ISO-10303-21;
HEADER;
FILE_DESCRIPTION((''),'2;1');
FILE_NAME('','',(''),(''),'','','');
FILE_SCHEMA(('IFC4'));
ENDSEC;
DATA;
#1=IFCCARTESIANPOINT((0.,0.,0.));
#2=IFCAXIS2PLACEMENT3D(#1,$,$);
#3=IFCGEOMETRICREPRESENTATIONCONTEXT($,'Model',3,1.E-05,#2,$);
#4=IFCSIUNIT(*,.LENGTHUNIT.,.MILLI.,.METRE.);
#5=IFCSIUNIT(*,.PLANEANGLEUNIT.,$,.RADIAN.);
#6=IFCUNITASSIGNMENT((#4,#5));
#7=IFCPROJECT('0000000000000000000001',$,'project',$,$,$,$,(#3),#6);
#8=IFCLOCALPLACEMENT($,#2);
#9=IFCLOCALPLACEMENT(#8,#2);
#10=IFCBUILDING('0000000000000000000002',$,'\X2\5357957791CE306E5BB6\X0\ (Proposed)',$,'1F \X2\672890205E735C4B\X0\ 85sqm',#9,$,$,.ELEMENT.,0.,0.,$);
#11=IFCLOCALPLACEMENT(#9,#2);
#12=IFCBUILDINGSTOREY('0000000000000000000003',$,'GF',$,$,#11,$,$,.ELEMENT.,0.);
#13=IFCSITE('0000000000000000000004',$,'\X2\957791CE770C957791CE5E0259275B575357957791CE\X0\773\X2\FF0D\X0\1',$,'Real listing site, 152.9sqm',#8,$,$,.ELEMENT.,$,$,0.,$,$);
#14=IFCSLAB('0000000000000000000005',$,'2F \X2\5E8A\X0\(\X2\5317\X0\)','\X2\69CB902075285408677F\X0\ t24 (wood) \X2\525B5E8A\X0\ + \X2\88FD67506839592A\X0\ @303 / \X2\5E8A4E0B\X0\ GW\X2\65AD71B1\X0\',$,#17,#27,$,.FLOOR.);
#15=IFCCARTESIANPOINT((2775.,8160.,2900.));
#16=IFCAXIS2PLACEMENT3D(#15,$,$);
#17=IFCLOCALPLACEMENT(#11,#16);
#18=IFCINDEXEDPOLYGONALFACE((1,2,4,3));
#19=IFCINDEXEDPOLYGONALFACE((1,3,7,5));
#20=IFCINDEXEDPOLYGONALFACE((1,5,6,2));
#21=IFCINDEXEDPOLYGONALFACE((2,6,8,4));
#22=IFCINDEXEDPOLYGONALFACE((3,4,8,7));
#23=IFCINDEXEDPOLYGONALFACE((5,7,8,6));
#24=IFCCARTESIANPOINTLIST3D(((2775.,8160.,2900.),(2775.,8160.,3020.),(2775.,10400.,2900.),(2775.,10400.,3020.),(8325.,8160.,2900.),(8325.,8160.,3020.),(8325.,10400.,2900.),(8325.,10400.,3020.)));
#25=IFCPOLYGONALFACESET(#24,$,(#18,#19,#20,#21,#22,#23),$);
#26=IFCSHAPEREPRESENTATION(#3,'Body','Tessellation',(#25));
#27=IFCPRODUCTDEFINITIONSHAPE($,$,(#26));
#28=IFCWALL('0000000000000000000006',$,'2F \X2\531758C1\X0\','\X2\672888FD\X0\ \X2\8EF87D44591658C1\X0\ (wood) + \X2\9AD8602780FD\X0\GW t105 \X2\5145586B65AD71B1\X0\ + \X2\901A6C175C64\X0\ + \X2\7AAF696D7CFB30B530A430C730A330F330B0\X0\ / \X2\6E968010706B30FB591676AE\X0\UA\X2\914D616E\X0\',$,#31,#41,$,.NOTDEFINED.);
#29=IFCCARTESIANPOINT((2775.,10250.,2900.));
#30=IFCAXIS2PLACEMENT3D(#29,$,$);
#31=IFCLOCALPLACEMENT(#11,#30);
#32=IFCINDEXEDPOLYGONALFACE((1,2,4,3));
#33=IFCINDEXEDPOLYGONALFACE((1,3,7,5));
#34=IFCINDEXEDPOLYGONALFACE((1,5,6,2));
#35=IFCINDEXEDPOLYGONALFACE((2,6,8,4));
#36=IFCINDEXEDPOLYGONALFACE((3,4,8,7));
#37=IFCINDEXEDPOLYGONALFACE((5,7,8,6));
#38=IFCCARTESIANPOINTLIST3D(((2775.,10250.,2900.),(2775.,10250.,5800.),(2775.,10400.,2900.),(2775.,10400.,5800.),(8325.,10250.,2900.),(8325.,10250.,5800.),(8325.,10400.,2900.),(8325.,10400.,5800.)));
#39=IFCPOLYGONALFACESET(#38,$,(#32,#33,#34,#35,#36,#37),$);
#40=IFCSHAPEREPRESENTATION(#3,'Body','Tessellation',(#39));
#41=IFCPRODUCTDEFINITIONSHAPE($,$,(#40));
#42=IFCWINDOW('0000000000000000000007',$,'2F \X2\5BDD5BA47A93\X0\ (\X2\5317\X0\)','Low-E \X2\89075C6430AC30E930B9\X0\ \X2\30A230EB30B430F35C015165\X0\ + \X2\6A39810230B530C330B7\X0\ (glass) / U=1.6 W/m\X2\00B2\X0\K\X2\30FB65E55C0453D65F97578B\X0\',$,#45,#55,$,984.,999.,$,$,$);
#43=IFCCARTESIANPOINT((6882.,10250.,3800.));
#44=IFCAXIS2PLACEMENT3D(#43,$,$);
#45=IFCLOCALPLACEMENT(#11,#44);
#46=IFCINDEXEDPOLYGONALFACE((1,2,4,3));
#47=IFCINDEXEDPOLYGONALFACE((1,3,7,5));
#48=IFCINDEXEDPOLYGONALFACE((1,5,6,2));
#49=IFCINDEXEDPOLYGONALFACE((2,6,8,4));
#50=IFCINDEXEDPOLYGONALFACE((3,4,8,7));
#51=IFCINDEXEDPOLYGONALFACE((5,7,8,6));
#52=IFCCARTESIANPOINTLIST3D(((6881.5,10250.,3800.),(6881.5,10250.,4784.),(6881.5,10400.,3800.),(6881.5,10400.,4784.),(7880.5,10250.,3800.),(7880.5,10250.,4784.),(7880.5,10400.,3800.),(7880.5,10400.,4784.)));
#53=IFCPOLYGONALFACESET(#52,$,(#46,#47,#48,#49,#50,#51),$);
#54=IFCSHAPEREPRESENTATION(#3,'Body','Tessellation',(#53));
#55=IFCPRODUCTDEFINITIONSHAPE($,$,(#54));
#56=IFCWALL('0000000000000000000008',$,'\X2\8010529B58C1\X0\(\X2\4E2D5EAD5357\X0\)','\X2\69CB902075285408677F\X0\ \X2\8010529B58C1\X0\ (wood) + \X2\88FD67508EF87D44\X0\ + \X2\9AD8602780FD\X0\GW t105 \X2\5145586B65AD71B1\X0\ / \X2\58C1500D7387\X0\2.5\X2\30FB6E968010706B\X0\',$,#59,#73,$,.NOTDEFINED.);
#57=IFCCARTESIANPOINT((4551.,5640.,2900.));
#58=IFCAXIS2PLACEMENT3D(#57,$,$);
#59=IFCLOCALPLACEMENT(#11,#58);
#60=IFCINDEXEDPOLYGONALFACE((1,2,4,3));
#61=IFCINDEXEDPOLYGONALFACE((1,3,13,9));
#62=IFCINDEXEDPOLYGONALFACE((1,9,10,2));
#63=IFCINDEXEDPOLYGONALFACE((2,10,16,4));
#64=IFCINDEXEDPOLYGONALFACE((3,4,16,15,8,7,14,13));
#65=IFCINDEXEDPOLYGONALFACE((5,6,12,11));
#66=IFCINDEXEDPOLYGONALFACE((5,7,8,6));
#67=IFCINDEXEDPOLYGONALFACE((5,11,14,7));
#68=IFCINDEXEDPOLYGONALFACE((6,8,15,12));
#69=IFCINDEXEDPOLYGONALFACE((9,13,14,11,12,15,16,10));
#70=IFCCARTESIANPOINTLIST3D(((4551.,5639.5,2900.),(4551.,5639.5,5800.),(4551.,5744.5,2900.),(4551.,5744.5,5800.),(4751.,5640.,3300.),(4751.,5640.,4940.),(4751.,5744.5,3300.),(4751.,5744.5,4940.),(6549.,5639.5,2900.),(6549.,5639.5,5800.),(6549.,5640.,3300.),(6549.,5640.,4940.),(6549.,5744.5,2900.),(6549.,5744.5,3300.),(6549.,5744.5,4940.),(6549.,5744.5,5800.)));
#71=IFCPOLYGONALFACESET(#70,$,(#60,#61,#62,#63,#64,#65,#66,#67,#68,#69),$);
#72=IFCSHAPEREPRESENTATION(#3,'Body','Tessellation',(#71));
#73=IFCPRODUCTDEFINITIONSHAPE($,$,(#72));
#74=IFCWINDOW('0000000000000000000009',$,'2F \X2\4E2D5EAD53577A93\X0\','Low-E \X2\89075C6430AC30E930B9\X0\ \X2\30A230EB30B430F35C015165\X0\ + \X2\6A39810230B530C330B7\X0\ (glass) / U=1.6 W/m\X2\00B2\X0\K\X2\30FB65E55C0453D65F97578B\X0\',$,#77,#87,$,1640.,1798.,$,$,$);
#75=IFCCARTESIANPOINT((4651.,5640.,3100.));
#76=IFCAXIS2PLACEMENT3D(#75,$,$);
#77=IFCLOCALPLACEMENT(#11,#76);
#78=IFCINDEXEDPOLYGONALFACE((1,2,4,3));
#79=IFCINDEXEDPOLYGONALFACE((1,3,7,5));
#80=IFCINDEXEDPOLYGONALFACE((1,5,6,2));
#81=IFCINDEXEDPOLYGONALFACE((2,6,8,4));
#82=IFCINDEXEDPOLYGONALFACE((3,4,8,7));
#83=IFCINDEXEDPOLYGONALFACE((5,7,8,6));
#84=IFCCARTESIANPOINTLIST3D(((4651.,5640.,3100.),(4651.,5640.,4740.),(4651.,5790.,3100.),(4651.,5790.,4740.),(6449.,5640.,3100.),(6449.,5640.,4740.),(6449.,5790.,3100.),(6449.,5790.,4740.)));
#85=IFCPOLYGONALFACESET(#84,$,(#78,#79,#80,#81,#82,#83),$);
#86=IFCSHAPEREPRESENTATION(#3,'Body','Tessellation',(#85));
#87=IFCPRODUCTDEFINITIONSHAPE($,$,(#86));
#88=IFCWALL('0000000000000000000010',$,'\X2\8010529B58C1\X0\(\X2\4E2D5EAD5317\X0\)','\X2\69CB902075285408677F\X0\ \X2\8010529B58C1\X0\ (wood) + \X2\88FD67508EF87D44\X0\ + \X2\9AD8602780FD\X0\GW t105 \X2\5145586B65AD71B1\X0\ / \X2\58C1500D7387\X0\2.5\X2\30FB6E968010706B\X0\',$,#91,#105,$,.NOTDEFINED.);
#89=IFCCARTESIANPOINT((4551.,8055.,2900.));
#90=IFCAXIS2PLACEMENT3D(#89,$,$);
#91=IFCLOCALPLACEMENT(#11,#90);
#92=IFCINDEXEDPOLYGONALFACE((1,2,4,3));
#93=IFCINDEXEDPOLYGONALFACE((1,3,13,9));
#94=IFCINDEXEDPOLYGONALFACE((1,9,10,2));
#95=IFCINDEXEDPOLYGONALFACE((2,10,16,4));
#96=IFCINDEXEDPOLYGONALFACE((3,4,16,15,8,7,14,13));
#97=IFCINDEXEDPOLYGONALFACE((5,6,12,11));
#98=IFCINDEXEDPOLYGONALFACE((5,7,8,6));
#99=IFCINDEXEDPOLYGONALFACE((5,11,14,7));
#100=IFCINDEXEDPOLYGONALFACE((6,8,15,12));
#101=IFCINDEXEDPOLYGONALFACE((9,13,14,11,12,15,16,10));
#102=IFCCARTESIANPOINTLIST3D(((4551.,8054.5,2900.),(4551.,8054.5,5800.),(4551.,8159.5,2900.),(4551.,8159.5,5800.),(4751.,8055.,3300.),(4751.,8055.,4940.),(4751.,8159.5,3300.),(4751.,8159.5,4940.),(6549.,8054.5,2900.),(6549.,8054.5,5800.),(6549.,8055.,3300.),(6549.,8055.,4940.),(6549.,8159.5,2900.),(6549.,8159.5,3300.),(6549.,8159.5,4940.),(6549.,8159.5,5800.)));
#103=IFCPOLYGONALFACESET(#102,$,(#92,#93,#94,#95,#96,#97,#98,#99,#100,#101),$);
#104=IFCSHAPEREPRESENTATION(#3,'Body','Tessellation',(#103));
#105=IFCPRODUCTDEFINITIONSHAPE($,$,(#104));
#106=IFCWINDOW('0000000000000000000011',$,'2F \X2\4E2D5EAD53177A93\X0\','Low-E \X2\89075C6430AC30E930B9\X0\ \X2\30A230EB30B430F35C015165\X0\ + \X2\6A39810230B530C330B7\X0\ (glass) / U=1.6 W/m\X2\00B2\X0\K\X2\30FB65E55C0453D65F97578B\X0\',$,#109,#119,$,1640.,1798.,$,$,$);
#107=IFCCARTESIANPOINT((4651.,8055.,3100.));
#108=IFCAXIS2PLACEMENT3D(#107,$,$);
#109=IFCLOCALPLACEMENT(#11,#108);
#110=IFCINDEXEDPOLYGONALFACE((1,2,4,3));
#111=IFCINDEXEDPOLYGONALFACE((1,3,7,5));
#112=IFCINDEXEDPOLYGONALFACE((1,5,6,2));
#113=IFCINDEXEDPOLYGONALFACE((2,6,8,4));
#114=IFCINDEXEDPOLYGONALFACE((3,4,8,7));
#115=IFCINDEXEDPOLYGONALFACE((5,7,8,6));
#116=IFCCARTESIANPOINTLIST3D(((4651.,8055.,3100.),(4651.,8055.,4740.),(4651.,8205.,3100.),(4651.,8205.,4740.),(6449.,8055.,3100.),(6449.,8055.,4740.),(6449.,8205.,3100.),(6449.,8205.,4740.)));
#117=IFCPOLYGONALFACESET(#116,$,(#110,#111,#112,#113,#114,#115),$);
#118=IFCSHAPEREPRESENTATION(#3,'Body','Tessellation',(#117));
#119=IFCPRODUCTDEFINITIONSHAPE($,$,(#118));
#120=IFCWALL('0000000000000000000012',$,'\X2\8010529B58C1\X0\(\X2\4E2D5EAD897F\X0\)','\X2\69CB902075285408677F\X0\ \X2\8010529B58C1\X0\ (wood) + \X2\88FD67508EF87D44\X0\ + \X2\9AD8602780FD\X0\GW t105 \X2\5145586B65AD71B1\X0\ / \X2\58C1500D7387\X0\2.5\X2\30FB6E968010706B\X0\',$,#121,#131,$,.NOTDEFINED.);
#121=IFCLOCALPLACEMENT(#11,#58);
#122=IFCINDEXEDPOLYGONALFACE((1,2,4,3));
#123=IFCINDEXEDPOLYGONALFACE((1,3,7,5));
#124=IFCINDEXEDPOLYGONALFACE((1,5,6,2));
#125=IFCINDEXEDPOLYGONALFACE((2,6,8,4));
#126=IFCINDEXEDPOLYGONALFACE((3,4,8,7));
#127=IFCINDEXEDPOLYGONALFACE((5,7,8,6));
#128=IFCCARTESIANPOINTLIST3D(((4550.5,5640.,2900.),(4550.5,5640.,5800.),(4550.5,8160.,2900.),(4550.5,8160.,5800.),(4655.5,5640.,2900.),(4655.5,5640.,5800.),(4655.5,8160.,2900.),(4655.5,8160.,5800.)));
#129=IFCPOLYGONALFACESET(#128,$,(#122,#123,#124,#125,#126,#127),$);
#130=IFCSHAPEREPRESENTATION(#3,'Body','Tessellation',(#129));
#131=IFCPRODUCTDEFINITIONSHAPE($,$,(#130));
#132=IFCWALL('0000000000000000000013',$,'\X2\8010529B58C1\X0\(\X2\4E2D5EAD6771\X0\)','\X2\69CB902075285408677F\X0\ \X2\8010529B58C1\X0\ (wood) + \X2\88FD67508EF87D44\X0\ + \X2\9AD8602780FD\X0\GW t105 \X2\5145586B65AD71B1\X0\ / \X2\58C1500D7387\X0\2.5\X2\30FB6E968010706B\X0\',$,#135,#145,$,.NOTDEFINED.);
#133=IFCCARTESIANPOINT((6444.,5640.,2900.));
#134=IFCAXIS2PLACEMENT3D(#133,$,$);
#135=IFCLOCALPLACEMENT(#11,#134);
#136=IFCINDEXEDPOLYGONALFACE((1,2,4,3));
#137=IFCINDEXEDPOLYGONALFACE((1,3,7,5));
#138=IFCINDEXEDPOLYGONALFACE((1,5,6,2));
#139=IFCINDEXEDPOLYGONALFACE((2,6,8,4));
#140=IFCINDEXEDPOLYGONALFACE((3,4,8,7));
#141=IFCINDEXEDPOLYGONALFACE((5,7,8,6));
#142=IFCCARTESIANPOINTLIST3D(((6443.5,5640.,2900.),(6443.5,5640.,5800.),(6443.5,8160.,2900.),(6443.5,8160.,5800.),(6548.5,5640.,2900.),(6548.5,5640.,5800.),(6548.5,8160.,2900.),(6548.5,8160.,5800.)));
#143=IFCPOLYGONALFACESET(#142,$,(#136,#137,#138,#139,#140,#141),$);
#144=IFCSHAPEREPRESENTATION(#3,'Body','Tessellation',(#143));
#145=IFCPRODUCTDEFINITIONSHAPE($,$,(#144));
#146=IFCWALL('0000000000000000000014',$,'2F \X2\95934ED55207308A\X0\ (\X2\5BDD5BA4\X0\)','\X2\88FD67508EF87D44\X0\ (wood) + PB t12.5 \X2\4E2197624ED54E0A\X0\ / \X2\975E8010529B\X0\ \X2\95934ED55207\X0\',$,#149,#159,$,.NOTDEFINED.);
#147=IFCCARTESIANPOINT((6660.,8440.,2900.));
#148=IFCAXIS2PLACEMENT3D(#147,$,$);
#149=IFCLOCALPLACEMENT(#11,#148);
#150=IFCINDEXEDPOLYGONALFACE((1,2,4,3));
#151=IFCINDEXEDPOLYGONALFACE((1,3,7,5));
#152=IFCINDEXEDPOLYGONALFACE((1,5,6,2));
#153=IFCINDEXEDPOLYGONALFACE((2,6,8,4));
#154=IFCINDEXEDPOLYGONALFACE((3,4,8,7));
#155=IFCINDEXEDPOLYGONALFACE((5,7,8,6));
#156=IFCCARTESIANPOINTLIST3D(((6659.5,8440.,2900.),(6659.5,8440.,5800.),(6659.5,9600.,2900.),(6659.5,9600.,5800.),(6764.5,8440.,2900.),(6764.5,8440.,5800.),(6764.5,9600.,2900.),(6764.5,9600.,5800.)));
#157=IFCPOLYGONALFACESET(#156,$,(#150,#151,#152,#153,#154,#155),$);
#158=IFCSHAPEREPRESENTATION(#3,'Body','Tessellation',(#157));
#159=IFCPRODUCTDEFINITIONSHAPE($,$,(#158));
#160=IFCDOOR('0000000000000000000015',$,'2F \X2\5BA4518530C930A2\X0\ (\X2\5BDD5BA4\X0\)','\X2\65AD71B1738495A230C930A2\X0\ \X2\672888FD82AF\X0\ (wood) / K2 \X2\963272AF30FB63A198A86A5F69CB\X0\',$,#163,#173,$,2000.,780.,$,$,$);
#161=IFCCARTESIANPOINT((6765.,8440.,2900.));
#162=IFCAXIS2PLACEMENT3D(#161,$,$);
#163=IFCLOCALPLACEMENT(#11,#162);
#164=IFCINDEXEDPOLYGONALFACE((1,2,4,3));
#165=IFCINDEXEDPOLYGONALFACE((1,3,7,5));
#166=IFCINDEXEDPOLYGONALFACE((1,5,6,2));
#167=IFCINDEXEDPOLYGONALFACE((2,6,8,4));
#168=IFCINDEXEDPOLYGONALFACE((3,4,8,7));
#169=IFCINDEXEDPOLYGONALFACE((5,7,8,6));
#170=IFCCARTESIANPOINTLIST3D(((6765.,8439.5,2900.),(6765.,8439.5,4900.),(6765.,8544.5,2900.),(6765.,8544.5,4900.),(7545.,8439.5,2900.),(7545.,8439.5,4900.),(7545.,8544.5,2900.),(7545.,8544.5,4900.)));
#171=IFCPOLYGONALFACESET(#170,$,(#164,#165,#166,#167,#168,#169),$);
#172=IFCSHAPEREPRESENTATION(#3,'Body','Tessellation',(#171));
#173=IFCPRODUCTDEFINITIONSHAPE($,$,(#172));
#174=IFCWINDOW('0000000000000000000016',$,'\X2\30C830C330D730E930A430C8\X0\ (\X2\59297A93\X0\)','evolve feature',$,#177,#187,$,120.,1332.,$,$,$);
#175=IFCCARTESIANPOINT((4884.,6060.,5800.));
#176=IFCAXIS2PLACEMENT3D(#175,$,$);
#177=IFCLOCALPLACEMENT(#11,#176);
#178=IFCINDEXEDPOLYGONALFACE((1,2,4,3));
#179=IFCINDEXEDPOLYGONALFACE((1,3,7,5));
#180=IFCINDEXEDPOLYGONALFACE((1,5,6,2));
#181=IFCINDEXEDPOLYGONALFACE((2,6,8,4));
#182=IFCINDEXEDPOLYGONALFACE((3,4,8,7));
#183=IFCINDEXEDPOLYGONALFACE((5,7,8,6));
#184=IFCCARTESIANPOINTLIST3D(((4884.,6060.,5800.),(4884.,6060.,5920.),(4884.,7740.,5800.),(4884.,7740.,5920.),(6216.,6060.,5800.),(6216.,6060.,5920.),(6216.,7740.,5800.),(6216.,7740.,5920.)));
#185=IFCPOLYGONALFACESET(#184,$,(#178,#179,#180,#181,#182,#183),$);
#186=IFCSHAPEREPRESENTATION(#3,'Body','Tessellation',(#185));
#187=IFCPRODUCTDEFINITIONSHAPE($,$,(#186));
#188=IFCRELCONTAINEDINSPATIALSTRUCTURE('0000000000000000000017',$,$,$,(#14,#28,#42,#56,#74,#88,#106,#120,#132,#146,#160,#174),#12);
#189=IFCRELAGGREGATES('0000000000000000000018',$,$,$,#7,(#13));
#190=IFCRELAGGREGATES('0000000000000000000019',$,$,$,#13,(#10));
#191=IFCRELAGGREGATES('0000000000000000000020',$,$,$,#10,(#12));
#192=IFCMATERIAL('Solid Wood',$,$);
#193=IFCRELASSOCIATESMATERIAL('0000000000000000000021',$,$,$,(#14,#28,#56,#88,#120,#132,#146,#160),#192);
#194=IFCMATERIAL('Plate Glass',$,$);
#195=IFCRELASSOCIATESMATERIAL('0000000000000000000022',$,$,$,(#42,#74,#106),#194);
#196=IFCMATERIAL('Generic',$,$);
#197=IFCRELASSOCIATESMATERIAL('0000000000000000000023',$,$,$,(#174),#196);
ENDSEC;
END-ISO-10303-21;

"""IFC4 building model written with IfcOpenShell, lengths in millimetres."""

from ifc_helpers import new_model, si_unit, frame, frame_2d, origin, place, context, project, spatial, rectangle, extrude, material, element, fill, save


model = new_model("IFC4")

# Units and contexts
model_context = context("Model", 3, precision=1e-05, world=origin())
ifc_project = project(units=[si_unit("LENGTHUNIT", "METRE", prefix="MILLI"), si_unit("PLANEANGLEUNIT", "RADIAN")], contexts=[model_context])

# Site, building, storey
site_placement = place(None, origin())
site = spatial("IfcSite", under=ifc_project, at=site_placement, Name="長野県長野市大字南長野773－1", ObjectType="Real listing site, 152.9sqm", CompositionType="ELEMENT", RefElevation=0.0)
building_placement = place(site_placement, origin())
building = spatial("IfcBuilding", under=site, at=building_placement, Name="南長野の家 (Proposed)", ObjectType="1F 木造平屋 85sqm", CompositionType="ELEMENT", ElevationOfRefHeight=0.0, ElevationOfTerrain=0.0)
storey_placement = place(building_placement, origin())
storey = spatial("IfcBuildingStorey", under=building, at=storey_placement, Name="GF", CompositionType="ELEMENT", Elevation=0.0)

# Slab
ifc_material_1 = material(Name="Solid Wood")
slab_placement = place(storey_placement, frame((2775.0, 8160.0, 2900.0)))
element("IfcSlab", 1, at=slab_placement, inside=storey, material=ifc_material_1, Name="2F 床(北)", Description="構造用合板 t24 (wood) 剛床 + 製材根太 @303 / 床下 GW断熱", PredefinedType="FLOOR", context=model_context, shape_type="SweptSolid", body=[
    extrude(rectangle(XDim=5550.0, YDim=2240.0, at=frame_2d((2775.0, 1120.0))), frame((2775.0, 8160.0, 2900.0)), (0.0, 0.0, 1.0), 120.0),
])

# Walls, openings, windows
wall_1_placement = place(storey_placement, frame((2775.0, 10250.0, 2900.0)))
wall_1 = element("IfcWall", 2, at=wall_1_placement, inside=storey, material=ifc_material_1, Name="2F 北壁", Description="木製 軸組外壁 (wood) + 高性能GW t105 充填断熱 + 通気層 + 窯業系サイディング / 準耐火・外皮UA配慮", PredefinedType="NOTDEFINED", context=model_context, shape_type="SweptSolid", body=[
    extrude(rectangle(XDim=5550.0, YDim=150.0, at=frame_2d((2775.0, 75.0))), frame((2775.0, 10250.0, 2900.0)), (0.0, 0.0, 1.0), 2900.0),
])
opening_1_placement = place(storey_placement, frame((6882.0, 10250.0, 3800.0)))
opening_1 = element("IfcOpeningElement", 3, at=opening_1_placement, cuts=wall_1, PredefinedType="NOTDEFINED", context=model_context, shape_type="SweptSolid", body=[
    extrude(rectangle(XDim=999.0, YDim=150.0, at=frame_2d((499.0, 75.0))), frame((6882.0, 10250.0, 3800.0)), (0.0, 0.0, 1.0), 984.0),
])
ifc_material_2 = material(Name="Plate Glass")
window_1_placement = place(storey_placement, frame((6882.0, 10250.0, 3800.0)))
window_1 = element("IfcWindow", 4, at=window_1_placement, inside=storey, material=ifc_material_2, Name="2F 寝室窓 (北)", Description="Low-E 複層ガラス アルゴン封入 + 樹脂サッシ (glass) / U=1.6 W/m²K・日射取得型", OverallHeight=984.0, OverallWidth=999.0, context=model_context, shape_type="SweptSolid", body=[
    extrude(rectangle(XDim=999.0, YDim=150.0, at=frame_2d((499.0, 75.0))), frame((6882.0, 10250.0, 3800.0)), (0.0, 0.0, 1.0), 984.0),
])
fill(opening_1, window_1)
wall_2_placement = place(storey_placement, frame((4551.0, 5640.0, 2900.0)))
wall_2 = element("IfcWall", 5, at=wall_2_placement, inside=storey, material=ifc_material_1, Name="耐力壁(中庭南)", Description="構造用合板 耐力壁 (wood) + 製材軸組 + 高性能GW t105 充填断熱 / 壁倍率2.5・準耐火", PredefinedType="NOTDEFINED", context=model_context, shape_type="SweptSolid", body=[
    extrude(rectangle(XDim=1998.0, YDim=105.0, at=frame_2d((999.0, 52.0))), frame((4551.0, 5640.0, 2900.0)), (0.0, 0.0, 1.0), 2900.0),
])
opening_2_placement = place(storey_placement, frame((4651.0, 5640.0, 3100.0)))
opening_2 = element("IfcOpeningElement", 6, at=opening_2_placement, cuts=wall_2, PredefinedType="NOTDEFINED", context=model_context, shape_type="SweptSolid", body=[
    extrude(rectangle(XDim=1798.0, YDim=150.0, at=frame_2d((899.0, 75.0))), frame((4651.0, 5640.0, 3100.0)), (0.0, 0.0, 1.0), 1640.0),
])
window_2_placement = place(storey_placement, frame((4651.0, 5640.0, 3100.0)))
window_2 = element("IfcWindow", 7, at=window_2_placement, inside=storey, material=ifc_material_2, Name="2F 中庭南窓", Description="Low-E 複層ガラス アルゴン封入 + 樹脂サッシ (glass) / U=1.6 W/m²K・日射取得型", OverallHeight=1640.0, OverallWidth=1798.0, context=model_context, shape_type="SweptSolid", body=[
    extrude(rectangle(XDim=1798.0, YDim=150.0, at=frame_2d((899.0, 75.0))), frame((4651.0, 5640.0, 3100.0)), (0.0, 0.0, 1.0), 1640.0),
])
fill(opening_2, window_2)
wall_3_placement = place(storey_placement, frame((4551.0, 8055.0, 2900.0)))
wall_3 = element("IfcWall", 8, at=wall_3_placement, inside=storey, material=ifc_material_1, Name="耐力壁(中庭北)", Description="構造用合板 耐力壁 (wood) + 製材軸組 + 高性能GW t105 充填断熱 / 壁倍率2.5・準耐火", PredefinedType="NOTDEFINED", context=model_context, shape_type="SweptSolid", body=[
    extrude(rectangle(XDim=1998.0, YDim=105.0, at=frame_2d((999.0, 52.0))), frame((4551.0, 8055.0, 2900.0)), (0.0, 0.0, 1.0), 2900.0),
])
opening_3_placement = place(storey_placement, frame((4651.0, 8055.0, 3100.0)))
opening_3 = element("IfcOpeningElement", 9, at=opening_3_placement, cuts=wall_3, PredefinedType="NOTDEFINED", context=model_context, shape_type="SweptSolid", body=[
    extrude(rectangle(XDim=1798.0, YDim=150.0, at=frame_2d((899.0, 75.0))), frame((4651.0, 8055.0, 3100.0)), (0.0, 0.0, 1.0), 1640.0),
])
window_3_placement = place(storey_placement, frame((4651.0, 8055.0, 3100.0)))
window_3 = element("IfcWindow", 10, at=window_3_placement, inside=storey, material=ifc_material_2, Name="2F 中庭北窓", Description="Low-E 複層ガラス アルゴン封入 + 樹脂サッシ (glass) / U=1.6 W/m²K・日射取得型", OverallHeight=1640.0, OverallWidth=1798.0, context=model_context, shape_type="SweptSolid", body=[
    extrude(rectangle(XDim=1798.0, YDim=150.0, at=frame_2d((899.0, 75.0))), frame((4651.0, 8055.0, 3100.0)), (0.0, 0.0, 1.0), 1640.0),
])
fill(opening_3, window_3)

# Walls
wall_4_placement = place(storey_placement, frame((4551.0, 5640.0, 2900.0)))
element("IfcWall", 11, at=wall_4_placement, inside=storey, material=ifc_material_1, Name="耐力壁(中庭西)", Description="構造用合板 耐力壁 (wood) + 製材軸組 + 高性能GW t105 充填断熱 / 壁倍率2.5・準耐火", PredefinedType="NOTDEFINED", context=model_context, shape_type="SweptSolid", body=[
    extrude(rectangle(XDim=105.0, YDim=2520.0, at=frame_2d((52.0, 1260.0))), frame((4551.0, 5640.0, 2900.0)), (0.0, 0.0, 1.0), 2900.0),
])
wall_5_placement = place(storey_placement, frame((6444.0, 5640.0, 2900.0)))
element("IfcWall", 12, at=wall_5_placement, inside=storey, material=ifc_material_1, Name="耐力壁(中庭東)", Description="構造用合板 耐力壁 (wood) + 製材軸組 + 高性能GW t105 充填断熱 / 壁倍率2.5・準耐火", PredefinedType="NOTDEFINED", context=model_context, shape_type="SweptSolid", body=[
    extrude(rectangle(XDim=105.0, YDim=2520.0, at=frame_2d((52.0, 1260.0))), frame((6444.0, 5640.0, 2900.0)), (0.0, 0.0, 1.0), 2900.0),
])
wall_6_placement = place(storey_placement, frame((6660.0, 8440.0, 2900.0)))
element("IfcWall", 13, at=wall_6_placement, inside=storey, material=ifc_material_1, Name="2F 間仕切り (寝室)", Description="製材軸組 (wood) + PB t12.5 両面仕上 / 非耐力 間仕切", PredefinedType="NOTDEFINED", context=model_context, shape_type="SweptSolid", body=[
    extrude(rectangle(XDim=105.0, YDim=1160.0, at=frame_2d((52.0, 580.0))), frame((6660.0, 8440.0, 2900.0)), (0.0, 0.0, 1.0), 2900.0),
])

# Door
door_placement = place(storey_placement, frame((6765.0, 8440.0, 2900.0)))
element("IfcDoor", 14, at=door_placement, inside=storey, material=ifc_material_1, Name="2F 室内ドア (寝室)", Description="断熱玄関ドア 木製芯 (wood) / K2 防犯・採風機構", OverallHeight=2000.0, OverallWidth=780.0, context=model_context, shape_type="SweptSolid", body=[
    extrude(rectangle(XDim=780.0, YDim=105.0, at=frame_2d((390.0, 52.0))), frame((6765.0, 8440.0, 2900.0)), (0.0, 0.0, 1.0), 2000.0),
])

# Window
ifc_material_3 = material(Name="Generic")
window_4_placement = place(storey_placement, frame((4884.0, 6060.0, 5800.0)))
element("IfcWindow", 15, at=window_4_placement, inside=storey, material=ifc_material_3, Name="トップライト (天窓)", Description="evolve feature", OverallHeight=120.0, OverallWidth=1332.0, context=model_context, shape_type="SweptSolid", body=[
    extrude(rectangle(XDim=1332.0, YDim=1680.0, at=frame_2d((666.0, 840.0))), frame((4884.0, 6060.0, 5800.0)), (0.0, 0.0, 1.0), 120.0),
])

save(model, "model.ifc")
